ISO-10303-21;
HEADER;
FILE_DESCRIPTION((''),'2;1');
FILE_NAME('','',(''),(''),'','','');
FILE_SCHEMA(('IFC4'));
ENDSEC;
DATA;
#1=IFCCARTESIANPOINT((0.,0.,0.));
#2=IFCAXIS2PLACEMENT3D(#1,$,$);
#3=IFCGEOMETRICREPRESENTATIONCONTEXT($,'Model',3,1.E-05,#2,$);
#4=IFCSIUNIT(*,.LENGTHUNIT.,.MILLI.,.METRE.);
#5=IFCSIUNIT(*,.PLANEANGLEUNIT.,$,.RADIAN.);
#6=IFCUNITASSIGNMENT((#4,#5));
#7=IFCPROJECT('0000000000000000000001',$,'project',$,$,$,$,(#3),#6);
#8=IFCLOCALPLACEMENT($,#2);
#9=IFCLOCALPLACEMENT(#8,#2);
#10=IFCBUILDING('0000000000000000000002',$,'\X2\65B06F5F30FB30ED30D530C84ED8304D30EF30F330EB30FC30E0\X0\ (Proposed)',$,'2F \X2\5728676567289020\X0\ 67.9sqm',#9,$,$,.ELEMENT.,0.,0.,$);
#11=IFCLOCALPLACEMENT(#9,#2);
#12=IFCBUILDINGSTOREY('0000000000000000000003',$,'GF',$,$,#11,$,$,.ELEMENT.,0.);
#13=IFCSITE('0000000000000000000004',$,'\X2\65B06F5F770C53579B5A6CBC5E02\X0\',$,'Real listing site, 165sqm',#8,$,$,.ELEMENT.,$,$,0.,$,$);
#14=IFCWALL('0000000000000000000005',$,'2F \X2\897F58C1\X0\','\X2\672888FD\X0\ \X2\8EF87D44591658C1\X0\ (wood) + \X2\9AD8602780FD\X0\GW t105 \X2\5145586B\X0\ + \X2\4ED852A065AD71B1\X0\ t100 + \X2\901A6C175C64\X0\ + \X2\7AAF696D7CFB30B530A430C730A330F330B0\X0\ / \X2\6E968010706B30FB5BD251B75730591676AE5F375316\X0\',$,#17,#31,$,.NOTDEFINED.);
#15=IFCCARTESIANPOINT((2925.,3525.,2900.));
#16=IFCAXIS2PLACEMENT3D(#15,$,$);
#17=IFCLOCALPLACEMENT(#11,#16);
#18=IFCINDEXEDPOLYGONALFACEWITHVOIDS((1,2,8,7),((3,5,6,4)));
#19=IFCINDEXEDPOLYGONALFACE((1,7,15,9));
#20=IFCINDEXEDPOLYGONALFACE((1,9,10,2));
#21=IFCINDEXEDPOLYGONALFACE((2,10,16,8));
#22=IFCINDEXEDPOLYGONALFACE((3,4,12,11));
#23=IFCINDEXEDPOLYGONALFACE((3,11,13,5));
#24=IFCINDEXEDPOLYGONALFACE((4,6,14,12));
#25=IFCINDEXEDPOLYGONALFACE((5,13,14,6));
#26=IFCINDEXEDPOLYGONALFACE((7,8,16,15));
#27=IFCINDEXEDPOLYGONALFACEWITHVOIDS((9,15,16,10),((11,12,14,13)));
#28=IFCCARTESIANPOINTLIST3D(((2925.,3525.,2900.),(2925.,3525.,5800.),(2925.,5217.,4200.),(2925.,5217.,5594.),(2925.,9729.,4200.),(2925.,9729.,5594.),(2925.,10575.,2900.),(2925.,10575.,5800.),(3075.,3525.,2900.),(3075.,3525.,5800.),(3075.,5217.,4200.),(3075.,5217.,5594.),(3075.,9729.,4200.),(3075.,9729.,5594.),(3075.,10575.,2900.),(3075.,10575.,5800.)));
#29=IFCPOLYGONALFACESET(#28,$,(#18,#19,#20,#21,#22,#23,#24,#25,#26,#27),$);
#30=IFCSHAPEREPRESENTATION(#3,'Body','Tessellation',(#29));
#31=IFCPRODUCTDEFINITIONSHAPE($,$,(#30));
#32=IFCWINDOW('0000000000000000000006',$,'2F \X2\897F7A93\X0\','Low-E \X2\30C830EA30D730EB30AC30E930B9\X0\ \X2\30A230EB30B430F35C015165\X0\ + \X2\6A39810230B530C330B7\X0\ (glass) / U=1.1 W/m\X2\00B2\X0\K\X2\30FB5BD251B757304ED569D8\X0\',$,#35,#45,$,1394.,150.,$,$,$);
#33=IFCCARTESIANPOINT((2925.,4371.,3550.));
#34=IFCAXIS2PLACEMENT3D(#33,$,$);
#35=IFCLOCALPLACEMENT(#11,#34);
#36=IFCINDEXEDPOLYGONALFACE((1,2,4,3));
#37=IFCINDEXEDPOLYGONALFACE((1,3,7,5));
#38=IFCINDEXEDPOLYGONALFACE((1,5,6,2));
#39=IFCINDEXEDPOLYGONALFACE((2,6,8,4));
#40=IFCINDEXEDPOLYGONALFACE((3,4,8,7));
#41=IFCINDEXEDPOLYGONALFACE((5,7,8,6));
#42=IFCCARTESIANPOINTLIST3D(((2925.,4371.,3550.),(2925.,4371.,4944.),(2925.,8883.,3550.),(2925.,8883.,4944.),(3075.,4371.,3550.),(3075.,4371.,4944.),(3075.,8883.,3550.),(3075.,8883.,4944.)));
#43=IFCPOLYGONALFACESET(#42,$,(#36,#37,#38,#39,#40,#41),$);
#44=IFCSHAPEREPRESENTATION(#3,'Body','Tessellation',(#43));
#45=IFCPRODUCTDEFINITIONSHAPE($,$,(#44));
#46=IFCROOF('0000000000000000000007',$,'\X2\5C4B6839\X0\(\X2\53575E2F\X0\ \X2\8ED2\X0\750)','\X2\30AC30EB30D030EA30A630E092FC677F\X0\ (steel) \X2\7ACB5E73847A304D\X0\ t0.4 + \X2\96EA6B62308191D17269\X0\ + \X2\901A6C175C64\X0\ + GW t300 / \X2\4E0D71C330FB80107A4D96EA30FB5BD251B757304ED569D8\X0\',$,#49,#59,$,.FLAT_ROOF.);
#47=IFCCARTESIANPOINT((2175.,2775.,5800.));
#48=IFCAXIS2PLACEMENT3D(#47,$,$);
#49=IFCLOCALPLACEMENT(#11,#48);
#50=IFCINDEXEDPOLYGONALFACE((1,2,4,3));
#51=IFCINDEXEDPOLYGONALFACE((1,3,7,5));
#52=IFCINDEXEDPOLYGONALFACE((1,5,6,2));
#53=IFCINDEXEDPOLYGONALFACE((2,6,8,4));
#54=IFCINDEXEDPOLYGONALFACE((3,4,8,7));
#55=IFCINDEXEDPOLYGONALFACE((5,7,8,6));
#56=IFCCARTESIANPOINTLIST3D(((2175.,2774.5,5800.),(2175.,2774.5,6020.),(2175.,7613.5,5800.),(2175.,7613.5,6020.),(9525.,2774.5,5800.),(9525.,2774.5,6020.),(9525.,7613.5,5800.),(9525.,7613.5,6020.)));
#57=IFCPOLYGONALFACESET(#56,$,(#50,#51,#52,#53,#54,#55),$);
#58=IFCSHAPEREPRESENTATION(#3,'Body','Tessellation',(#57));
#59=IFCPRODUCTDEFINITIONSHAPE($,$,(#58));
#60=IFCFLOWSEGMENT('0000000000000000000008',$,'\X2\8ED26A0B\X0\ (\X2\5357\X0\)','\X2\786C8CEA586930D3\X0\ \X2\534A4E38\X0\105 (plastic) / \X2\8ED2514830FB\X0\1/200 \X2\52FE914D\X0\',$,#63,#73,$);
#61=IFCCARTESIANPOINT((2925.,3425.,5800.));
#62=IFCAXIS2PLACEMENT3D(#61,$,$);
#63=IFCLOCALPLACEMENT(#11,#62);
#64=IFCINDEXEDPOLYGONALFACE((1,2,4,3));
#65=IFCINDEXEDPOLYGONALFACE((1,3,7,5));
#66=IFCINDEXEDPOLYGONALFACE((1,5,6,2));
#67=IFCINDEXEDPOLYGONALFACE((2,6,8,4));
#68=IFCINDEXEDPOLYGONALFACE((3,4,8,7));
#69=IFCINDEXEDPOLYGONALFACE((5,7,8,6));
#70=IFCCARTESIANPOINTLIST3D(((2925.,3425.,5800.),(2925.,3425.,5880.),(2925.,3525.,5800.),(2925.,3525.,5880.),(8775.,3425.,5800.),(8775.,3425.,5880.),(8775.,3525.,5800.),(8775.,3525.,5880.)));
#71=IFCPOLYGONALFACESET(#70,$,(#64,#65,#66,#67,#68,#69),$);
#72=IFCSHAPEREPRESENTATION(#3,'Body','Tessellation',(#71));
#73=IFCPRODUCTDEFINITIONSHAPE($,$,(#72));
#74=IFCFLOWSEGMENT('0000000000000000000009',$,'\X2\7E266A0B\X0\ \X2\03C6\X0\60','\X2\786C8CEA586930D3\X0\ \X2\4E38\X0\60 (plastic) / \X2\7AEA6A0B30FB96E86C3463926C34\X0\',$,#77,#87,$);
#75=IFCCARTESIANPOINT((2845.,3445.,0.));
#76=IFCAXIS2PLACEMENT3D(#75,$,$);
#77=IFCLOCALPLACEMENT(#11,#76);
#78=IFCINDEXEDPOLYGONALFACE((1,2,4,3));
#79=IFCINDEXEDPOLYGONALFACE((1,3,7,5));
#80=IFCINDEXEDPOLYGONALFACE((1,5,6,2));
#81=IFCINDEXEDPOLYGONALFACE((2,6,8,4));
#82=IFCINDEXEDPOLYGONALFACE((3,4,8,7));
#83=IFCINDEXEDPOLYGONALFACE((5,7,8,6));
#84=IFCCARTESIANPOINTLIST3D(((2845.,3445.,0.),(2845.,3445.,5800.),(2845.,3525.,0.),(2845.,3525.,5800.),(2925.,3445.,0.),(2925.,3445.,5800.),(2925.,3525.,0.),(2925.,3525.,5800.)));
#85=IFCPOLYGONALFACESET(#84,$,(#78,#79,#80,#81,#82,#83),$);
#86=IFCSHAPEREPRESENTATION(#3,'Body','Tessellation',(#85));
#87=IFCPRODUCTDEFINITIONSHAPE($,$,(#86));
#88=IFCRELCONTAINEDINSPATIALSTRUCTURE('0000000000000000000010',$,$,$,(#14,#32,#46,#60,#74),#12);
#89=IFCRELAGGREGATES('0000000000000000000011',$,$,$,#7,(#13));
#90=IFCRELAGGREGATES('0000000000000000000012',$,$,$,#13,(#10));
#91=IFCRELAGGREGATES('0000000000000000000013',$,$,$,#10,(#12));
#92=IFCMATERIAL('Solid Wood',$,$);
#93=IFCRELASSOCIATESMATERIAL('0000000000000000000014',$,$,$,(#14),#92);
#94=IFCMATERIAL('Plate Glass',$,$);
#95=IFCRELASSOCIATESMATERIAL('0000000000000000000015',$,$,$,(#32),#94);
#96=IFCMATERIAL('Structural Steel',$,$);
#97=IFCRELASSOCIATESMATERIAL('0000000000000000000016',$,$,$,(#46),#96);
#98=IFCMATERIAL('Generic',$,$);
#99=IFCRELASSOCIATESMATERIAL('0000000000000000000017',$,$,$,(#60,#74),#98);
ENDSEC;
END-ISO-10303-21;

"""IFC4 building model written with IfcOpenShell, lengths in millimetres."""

from ifc_helpers import new_model, si_unit, frame, frame_2d, origin, place, context, project, spatial, rectangle, extrude, material, element, fill, save


model = new_model("IFC4")

# Units and contexts
model_context = context("Model", 3, precision=1e-05, world=origin())
ifc_project = project(units=[si_unit("LENGTHUNIT", "METRE", prefix="MILLI"), si_unit("PLANEANGLEUNIT", "RADIAN")], contexts=[model_context])

# Site, building, storey
site_placement = place(None, origin())
site = spatial("IfcSite", under=ifc_project, at=site_placement, Name="新潟県南魚沼市", ObjectType="Real listing site, 165sqm", CompositionType="ELEMENT", RefElevation=0.0)
building_placement = place(site_placement, origin())
building = spatial("IfcBuilding", under=site, at=building_placement, Name="新潟・ロフト付きワンルーム (Proposed)", ObjectType="2F 在来木造 67.9sqm", CompositionType="ELEMENT", ElevationOfRefHeight=0.0, ElevationOfTerrain=0.0)
storey_placement = place(building_placement, origin())
storey = spatial("IfcBuildingStorey", under=building, at=storey_placement, Name="GF", CompositionType="ELEMENT", Elevation=0.0)

# Shared definitions
ifc_material_1 = material(Name="Solid Wood")

# Shared definitions
ifc_material_2 = material(Name="Plate Glass")

# Wall, opening, window
wall_1_placement = place(storey_placement, frame((2925.0, 3525.0, 2900.0)))
wall_1 = element("IfcWall", 1, at=wall_1_placement, inside=storey, material=ifc_material_1, Name="2F 西壁", Description="木製 軸組外壁 (wood) + 高性能GW t105 充填 + 付加断熱 t100 + 通気層 + 窯業系サイディング / 準耐火・寒冷地外皮強化", PredefinedType="NOTDEFINED", context=model_context, shape_type="SweptSolid", body=[
    extrude(rectangle(XDim=150.0, YDim=7050.0, at=frame_2d((75.0, 3525.0))), frame((2925.0, 3525.0, 2900.0)), (0.0, 0.0, 1.0), 2900.0),
])
opening_1_placement = place(storey_placement, frame((2925.0, 4371.0, 3550.0)))
opening_1 = element("IfcOpeningElement", 2, at=opening_1_placement, cuts=wall_1, PredefinedType="NOTDEFINED", context=model_context, shape_type="SweptSolid", body=[
    extrude(rectangle(XDim=150.0, YDim=4512.0, at=frame_2d((75.0, 2256.0))), frame((2925.0, 4371.0, 3550.0)), (0.0, 0.0, 1.0), 1394.0),
])
window_1_placement = place(storey_placement, frame((2925.0, 4371.0, 3550.0)))
window_1 = element("IfcWindow", 3, at=window_1_placement, inside=storey, material=ifc_material_2, Name="2F 西窓", Description="Low-E トリプルガラス アルゴン封入 + 樹脂サッシ (glass) / U=1.1 W/m²K・寒冷地仕様", OverallHeight=1394.0, OverallWidth=150.0, context=model_context, shape_type="SweptSolid", body=[
    extrude(rectangle(XDim=150.0, YDim=4512.0, at=frame_2d((75.0, 2256.0))), frame((2925.0, 4371.0, 3550.0)), (0.0, 0.0, 1.0), 1394.0),
])
fill(opening_1, window_1)

# Roof
ifc_material_3 = material(Name="Structural Steel")
for number, where, name in (
    (4, (2175.0, 2775.0, 5800.0), "屋根(南帯 軒750)"),
):
    element("IfcRoof", number, at=place(storey_placement, frame(where)), inside=storey, material=ifc_material_3, Name=name, Description="ガルバリウム鋼板 (steel) 立平葺き t0.4 + 雪止め金物 + 通気層 + GW t300 / 不燃・耐積雪・寒冷地仕様", PredefinedType="FLAT_ROOF", context=model_context, shape_type="SweptSolid", body=[
        extrude(rectangle(XDim=7350.0, YDim=4839.0, at=frame_2d((3675.0, 2419.0))), frame((2175.0, 2775.0, 5800.0)), (0.0, 0.0, 1.0), 220.0),
    ])

# Flow segments
ifc_material_4 = material(Name="Generic")
flow_segment_1_placement = place(storey_placement, frame((2925.0, 3425.0, 5800.0)))
element("IfcFlowSegment", 5, at=flow_segment_1_placement, inside=storey, material=ifc_material_4, Name="軒樋 (南)", Description="硬質塩ビ 半丸105 (plastic) / 軒先・1/200 勾配", context=model_context, shape_type="SweptSolid", body=[
    extrude(rectangle(XDim=5850.0, YDim=100.0, at=frame_2d((2925.0, 50.0))), frame((2925.0, 3425.0, 5800.0)), (0.0, 0.0, 1.0), 80.0),
])
flow_segment_2_placement = place(storey_placement, frame((2845.0, 3445.0, 0.0)))
element("IfcFlowSegment", 6, at=flow_segment_2_placement, inside=storey, material=ifc_material_4, Name="縦樋 φ60", Description="硬質塩ビ 丸60 (plastic) / 竪樋・雨水排水", context=model_context, shape_type="SweptSolid", body=[
    extrude(rectangle(XDim=80.0, YDim=80.0, at=frame_2d((40.0, 40.0))), frame((2845.0, 3445.0, 0.0)), (0.0, 0.0, 1.0), 5800.0),
])

save(model, "model.ifc")
